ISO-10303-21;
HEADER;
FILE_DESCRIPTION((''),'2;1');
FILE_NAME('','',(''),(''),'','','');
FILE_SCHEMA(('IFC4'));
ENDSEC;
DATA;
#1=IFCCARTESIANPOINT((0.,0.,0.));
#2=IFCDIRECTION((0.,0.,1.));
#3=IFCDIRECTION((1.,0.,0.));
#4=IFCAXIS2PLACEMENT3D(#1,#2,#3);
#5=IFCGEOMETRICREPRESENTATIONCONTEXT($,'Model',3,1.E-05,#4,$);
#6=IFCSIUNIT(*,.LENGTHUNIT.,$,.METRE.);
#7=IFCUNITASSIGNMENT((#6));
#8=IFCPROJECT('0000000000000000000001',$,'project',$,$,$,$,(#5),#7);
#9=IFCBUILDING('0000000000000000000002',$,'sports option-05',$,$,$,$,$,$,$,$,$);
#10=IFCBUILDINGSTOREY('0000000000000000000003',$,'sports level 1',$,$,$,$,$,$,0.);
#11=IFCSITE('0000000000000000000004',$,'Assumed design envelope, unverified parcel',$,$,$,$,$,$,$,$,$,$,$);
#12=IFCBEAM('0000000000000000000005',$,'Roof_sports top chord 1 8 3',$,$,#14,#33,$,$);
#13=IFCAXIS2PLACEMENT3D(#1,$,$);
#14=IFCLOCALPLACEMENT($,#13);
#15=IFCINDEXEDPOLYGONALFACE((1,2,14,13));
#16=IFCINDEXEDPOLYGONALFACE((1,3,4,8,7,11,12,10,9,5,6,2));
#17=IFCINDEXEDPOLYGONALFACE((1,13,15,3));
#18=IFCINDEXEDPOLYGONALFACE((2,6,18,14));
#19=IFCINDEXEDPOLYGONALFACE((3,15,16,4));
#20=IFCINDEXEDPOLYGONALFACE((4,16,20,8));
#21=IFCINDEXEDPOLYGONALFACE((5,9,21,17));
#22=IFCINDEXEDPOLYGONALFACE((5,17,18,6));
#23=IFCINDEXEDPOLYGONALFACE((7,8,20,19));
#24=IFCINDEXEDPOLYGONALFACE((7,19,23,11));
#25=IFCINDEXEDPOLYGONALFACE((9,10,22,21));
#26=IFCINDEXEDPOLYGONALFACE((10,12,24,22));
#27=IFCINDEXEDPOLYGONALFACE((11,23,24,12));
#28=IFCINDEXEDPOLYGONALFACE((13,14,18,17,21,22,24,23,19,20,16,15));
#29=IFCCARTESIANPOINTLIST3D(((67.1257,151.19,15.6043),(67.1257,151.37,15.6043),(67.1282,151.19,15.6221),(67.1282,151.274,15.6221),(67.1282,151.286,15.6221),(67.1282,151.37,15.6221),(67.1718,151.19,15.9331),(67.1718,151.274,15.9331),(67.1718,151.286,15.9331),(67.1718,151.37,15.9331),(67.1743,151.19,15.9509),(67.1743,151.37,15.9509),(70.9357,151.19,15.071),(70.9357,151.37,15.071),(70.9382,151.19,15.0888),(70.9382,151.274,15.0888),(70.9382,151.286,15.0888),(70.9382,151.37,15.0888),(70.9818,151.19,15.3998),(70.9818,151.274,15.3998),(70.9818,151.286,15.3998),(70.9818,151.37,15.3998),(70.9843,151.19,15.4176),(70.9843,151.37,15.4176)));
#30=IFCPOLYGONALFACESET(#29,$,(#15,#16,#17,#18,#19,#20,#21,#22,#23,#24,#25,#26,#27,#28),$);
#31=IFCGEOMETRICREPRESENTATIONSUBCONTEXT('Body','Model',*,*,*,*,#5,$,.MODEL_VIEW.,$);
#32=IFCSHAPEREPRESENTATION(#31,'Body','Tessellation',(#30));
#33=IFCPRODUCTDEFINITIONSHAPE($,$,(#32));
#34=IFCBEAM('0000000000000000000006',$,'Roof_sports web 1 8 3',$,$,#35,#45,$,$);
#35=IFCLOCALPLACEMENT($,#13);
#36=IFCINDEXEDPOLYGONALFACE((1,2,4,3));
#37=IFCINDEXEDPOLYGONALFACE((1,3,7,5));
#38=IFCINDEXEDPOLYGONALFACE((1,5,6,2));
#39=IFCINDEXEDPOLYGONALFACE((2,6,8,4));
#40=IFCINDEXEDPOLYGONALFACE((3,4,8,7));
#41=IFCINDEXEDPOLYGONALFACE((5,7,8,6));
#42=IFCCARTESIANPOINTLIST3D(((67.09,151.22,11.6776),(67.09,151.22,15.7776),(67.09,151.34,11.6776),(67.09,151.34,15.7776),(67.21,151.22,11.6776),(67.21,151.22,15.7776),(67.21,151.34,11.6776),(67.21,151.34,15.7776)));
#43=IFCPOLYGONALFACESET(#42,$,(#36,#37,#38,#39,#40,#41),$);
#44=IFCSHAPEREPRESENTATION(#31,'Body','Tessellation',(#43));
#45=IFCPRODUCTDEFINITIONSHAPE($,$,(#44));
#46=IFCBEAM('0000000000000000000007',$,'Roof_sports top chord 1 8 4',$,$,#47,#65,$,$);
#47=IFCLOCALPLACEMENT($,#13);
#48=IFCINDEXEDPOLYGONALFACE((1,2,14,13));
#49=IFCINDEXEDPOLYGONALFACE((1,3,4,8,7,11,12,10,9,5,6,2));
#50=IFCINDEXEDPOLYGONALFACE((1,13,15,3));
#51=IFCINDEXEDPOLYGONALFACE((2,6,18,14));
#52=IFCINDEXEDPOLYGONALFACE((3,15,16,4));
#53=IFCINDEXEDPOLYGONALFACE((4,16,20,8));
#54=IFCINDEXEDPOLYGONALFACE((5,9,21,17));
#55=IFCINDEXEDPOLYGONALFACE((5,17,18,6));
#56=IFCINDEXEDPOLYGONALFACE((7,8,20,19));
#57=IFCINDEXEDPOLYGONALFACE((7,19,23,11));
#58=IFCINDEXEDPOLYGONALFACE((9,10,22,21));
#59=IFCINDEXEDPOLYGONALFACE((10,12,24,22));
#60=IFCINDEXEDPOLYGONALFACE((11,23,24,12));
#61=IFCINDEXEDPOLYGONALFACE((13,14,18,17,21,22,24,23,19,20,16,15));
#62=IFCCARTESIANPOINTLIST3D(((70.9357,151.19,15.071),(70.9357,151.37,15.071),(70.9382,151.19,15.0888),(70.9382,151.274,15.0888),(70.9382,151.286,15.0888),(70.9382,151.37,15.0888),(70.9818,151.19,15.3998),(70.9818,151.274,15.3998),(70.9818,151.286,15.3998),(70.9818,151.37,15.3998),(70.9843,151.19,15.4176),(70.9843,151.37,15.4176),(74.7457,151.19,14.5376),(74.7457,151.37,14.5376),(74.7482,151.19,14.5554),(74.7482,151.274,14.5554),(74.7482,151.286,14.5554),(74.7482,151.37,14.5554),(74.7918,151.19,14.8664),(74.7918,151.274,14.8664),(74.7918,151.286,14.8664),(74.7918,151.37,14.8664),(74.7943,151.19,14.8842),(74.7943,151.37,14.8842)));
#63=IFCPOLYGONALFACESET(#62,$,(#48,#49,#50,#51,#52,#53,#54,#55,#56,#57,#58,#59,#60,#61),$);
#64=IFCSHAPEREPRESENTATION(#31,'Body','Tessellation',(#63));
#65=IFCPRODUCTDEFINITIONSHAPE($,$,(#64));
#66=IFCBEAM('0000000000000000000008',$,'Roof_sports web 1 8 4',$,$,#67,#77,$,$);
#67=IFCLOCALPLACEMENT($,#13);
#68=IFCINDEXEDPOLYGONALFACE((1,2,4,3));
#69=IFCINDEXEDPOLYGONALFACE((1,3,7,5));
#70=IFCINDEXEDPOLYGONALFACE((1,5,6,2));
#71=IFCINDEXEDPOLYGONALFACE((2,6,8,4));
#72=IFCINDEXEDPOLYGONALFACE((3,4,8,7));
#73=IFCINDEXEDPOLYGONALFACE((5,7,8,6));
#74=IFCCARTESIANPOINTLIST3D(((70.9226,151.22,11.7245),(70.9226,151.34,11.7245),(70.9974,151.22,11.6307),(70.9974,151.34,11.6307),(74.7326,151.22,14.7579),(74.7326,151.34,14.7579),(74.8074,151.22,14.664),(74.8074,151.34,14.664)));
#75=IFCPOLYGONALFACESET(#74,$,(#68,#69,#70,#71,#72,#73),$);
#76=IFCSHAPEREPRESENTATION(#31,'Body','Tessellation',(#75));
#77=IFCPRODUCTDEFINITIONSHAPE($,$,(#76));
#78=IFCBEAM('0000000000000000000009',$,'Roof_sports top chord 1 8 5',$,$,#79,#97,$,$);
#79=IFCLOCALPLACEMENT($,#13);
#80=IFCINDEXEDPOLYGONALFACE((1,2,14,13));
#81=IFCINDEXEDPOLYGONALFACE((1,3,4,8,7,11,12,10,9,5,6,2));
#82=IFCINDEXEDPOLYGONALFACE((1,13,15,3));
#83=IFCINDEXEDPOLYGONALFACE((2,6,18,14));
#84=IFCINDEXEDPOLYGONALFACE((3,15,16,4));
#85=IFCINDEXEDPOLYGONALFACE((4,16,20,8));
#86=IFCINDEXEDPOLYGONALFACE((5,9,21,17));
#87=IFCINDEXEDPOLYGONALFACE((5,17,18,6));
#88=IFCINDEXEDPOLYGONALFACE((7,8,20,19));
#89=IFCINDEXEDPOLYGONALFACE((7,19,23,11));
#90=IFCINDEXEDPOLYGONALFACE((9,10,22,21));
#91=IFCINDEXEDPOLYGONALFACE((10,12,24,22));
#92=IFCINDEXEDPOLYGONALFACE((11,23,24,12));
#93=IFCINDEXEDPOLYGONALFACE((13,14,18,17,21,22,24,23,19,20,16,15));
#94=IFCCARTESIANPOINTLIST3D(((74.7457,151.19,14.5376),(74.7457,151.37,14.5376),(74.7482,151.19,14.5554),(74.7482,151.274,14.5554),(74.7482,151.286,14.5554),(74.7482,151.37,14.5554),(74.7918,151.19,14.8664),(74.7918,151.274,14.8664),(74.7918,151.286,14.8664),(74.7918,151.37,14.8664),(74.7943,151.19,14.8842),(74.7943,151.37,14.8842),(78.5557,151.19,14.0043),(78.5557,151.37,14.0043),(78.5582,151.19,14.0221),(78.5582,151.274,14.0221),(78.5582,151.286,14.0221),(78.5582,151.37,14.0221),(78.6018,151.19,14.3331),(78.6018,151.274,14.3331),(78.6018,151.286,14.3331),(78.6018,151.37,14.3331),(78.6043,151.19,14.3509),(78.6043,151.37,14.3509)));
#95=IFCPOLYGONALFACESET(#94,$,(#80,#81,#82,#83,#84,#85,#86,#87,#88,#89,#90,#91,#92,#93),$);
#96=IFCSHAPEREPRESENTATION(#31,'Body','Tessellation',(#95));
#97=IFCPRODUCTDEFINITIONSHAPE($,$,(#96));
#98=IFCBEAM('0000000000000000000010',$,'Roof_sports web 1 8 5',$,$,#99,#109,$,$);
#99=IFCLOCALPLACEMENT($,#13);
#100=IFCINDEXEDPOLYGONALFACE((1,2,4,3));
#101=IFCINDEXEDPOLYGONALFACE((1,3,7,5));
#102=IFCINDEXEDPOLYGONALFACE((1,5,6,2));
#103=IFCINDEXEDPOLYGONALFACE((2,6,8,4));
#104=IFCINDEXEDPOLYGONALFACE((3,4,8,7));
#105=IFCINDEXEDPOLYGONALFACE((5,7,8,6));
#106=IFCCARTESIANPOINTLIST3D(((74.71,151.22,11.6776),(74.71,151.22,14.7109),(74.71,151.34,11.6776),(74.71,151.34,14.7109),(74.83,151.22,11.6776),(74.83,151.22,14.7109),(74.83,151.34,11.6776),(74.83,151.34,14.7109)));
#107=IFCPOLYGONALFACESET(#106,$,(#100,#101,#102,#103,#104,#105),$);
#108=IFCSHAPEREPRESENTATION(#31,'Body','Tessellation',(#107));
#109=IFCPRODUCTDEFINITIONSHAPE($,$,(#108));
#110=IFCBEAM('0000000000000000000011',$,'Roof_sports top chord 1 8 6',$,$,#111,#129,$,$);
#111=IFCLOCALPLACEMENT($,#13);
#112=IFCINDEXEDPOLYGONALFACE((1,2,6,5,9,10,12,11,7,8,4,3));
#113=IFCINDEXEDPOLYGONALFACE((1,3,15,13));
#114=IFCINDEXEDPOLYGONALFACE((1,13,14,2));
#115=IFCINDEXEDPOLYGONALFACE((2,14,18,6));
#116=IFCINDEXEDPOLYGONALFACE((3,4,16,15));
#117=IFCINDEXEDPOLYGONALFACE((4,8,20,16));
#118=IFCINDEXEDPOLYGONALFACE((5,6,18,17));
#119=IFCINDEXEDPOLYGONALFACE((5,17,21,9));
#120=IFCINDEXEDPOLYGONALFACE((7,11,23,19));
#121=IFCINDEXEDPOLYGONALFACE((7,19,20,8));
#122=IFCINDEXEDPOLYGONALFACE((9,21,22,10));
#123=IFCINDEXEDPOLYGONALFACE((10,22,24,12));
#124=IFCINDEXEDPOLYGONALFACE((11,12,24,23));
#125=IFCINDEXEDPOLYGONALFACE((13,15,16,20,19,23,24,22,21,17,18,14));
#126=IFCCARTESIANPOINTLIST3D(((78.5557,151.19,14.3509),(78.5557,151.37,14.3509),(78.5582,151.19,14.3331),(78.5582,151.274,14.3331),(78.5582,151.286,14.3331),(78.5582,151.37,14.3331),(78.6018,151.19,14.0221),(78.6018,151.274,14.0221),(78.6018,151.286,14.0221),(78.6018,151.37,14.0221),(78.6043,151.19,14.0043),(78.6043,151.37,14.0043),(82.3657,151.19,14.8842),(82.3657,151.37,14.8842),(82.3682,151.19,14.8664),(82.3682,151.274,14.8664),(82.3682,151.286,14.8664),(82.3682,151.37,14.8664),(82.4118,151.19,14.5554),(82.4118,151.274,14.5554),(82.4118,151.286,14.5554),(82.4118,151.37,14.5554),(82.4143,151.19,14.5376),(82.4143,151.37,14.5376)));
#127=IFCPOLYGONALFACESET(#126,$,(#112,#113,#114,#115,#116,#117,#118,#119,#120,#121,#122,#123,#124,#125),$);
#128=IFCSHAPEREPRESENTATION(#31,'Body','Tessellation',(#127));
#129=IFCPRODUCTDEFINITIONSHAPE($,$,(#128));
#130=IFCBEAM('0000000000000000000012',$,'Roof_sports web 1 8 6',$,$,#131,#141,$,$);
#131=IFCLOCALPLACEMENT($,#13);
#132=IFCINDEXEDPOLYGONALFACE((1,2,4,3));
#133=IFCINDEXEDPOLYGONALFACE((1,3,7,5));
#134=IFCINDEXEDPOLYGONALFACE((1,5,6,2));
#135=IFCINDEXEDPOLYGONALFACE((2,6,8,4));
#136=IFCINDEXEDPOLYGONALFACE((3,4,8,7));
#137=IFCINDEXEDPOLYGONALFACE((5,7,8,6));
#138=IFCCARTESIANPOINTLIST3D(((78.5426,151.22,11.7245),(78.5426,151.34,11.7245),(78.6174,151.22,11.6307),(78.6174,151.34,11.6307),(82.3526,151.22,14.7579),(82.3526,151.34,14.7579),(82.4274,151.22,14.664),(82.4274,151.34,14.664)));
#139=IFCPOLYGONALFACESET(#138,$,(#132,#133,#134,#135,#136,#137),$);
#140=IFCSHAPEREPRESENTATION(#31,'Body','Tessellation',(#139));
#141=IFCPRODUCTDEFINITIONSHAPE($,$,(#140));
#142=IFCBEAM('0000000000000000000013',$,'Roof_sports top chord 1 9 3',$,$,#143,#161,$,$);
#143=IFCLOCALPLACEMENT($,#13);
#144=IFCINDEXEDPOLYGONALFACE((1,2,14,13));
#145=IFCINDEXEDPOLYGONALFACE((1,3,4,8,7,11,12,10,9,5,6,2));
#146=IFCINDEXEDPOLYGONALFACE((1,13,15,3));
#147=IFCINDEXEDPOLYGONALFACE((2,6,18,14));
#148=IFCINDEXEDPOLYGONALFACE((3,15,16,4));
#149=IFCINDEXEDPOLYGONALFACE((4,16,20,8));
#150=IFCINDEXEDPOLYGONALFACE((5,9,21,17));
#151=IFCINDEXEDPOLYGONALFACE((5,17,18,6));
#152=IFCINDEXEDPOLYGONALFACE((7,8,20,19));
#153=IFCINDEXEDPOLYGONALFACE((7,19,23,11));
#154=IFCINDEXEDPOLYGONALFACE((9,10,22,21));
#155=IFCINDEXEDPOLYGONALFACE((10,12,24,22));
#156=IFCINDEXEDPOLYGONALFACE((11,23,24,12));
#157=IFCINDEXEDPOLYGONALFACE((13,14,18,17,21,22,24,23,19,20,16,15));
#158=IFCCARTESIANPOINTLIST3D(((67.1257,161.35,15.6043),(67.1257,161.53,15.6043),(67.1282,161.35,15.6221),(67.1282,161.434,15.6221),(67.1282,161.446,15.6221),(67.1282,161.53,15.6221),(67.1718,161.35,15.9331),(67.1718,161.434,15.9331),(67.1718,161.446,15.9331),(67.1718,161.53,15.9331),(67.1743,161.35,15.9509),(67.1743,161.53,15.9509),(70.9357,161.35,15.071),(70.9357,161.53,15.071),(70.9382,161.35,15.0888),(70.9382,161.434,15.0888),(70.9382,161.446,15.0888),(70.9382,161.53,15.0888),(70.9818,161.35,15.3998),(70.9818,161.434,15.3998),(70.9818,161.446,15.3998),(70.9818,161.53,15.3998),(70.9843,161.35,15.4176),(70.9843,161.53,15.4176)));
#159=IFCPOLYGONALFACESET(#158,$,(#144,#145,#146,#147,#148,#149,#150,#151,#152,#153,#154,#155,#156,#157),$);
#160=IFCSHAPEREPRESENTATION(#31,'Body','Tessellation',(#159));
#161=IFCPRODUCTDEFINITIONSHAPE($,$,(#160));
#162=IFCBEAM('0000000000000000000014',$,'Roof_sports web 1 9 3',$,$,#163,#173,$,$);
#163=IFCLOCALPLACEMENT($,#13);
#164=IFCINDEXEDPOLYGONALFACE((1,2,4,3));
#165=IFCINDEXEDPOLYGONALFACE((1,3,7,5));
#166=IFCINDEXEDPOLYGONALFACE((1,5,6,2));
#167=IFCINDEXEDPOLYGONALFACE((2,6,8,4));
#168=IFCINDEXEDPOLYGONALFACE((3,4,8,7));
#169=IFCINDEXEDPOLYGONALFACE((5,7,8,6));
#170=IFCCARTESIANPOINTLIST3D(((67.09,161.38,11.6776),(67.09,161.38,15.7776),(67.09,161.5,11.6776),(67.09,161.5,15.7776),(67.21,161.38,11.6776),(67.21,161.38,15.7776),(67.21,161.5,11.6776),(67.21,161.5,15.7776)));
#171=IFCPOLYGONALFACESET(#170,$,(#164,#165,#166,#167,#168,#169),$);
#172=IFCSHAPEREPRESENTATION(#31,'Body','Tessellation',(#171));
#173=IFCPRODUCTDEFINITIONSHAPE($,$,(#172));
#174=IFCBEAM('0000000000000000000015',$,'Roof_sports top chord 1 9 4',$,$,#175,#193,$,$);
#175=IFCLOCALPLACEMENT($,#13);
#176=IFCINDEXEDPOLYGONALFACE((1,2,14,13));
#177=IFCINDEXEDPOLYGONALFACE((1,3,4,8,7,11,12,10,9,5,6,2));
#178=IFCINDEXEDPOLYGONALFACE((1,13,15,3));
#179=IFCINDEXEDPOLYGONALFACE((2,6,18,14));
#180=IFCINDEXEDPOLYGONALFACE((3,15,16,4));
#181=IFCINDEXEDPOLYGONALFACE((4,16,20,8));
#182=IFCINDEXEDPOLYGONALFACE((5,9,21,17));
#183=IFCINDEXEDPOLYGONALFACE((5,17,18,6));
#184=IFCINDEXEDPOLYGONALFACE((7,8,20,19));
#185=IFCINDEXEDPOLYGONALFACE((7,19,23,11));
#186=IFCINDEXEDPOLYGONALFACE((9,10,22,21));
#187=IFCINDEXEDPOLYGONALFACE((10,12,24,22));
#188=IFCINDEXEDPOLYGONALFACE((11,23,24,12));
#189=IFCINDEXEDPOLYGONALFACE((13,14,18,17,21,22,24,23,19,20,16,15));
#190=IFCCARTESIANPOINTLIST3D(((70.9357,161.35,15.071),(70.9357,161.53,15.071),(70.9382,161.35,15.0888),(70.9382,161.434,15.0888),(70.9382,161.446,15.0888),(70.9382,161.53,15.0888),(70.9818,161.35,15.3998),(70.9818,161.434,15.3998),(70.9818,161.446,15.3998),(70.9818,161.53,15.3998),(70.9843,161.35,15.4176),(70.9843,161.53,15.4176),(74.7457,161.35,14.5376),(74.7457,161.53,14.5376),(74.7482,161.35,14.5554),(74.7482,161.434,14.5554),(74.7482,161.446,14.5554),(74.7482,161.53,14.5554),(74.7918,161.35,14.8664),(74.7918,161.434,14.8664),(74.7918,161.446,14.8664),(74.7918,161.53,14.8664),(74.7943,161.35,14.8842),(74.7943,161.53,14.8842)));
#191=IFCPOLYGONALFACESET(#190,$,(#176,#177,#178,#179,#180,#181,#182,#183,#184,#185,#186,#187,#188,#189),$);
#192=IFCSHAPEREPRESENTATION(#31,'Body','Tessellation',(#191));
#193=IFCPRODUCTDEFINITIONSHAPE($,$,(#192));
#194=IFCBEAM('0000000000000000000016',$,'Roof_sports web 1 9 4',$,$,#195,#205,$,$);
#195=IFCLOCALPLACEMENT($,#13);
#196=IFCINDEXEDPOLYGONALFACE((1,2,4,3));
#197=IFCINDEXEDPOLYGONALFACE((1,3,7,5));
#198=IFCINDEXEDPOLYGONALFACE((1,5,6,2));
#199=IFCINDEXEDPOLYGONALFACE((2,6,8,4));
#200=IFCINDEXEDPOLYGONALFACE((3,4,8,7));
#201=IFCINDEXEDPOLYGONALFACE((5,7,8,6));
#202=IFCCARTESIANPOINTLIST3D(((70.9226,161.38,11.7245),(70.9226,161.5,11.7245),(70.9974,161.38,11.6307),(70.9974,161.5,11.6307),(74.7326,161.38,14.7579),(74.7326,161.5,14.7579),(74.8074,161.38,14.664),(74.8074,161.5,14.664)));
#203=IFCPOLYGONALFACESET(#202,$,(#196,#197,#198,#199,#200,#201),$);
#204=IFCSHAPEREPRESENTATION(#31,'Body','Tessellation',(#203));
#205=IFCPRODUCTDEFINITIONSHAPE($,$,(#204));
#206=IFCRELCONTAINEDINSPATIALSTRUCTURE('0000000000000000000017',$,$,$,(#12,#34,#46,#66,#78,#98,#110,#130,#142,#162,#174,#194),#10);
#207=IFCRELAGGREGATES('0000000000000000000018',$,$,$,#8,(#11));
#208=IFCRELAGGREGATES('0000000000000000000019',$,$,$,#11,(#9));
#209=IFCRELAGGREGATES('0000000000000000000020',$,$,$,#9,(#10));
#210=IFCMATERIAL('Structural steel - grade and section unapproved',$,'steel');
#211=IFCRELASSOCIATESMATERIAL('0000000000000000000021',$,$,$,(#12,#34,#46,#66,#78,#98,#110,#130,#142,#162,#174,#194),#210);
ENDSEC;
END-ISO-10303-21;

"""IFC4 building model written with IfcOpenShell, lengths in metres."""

from ifc_helpers import new_model, si_unit, frame, origin_with_axes, place, context, subcontext, project, spatial, rectangle, i_section, extrude, material, element, save


model = new_model("IFC4")

# Units and contexts
model_context = context("Model", 3, precision=1e-05, world=origin_with_axes())
body_context = subcontext(model_context, "Body", "Model", "MODEL_VIEW")
ifc_project = project(units=[si_unit("LENGTHUNIT", "METRE")], contexts=[model_context])

# Site, building, storey
site = spatial("IfcSite", under=ifc_project, Name="Assumed design envelope, unverified parcel")
building = spatial("IfcBuilding", under=site, Name="sports option-05")
storey = spatial("IfcBuildingStorey", under=building, Name="sports level 1", Elevation=0.0)

# Beams
ifc_material = material(Name="Structural steel - grade and section unapproved", Category="steel")
beam_1_placement = place(None, frame((67.15, 151.28, 15.7776), z_axis=(0.990344, 0.0, -0.138631), x_axis=(0.0, 1.0, 0.0)))
element("IfcBeam", 1, at=beam_1_placement, inside=storey, material=ifc_material, Name="Roof_sports top chord 1 8 3", context=body_context, shape_type="SweptSolid", body=[
    extrude(i_section(OverallWidth=0.18, OverallDepth=0.35, WebThickness=0.012, FlangeThickness=0.018, FilletRadius=0.0), origin_with_axes(), (0.0, 0.0, 1.0), 3.8471),
])
beam_2_placement = place(None, frame((67.15, 151.28, 11.6776), z_axis=(0.0, 0.0, 1.0), x_axis=(-1.0, 0.0, 0.0)))
element("IfcBeam", 2, at=beam_2_placement, inside=storey, material=ifc_material, Name="Roof_sports web 1 8 3", context=body_context, shape_type="SweptSolid", body=[
    extrude(rectangle(XDim=0.12, YDim=0.12), origin_with_axes(), (0.0, 0.0, 1.0), 4.1),
])
beam_3_placement = place(None, frame((70.96, 151.28, 15.2443), z_axis=(0.990344, 0.0, -0.138631), x_axis=(0.0, 1.0, 0.0)))
element("IfcBeam", 3, at=beam_3_placement, inside=storey, material=ifc_material, Name="Roof_sports top chord 1 8 4", context=body_context, shape_type="SweptSolid", body=[
    extrude(i_section(OverallWidth=0.18, OverallDepth=0.35, WebThickness=0.012, FlangeThickness=0.018, FilletRadius=0.0), origin_with_axes(), (0.0, 0.0, 1.0), 3.8471),
])
beam_4_placement = place(None, frame((70.96, 151.28, 11.6776), z_axis=(0.782336, 0.0, 0.622857), x_axis=(0.0, 1.0, 0.0)))
element("IfcBeam", 4, at=beam_4_placement, inside=storey, material=ifc_material, Name="Roof_sports web 1 8 4", context=body_context, shape_type="SweptSolid", body=[
    extrude(rectangle(XDim=0.12, YDim=0.12), origin_with_axes(), (0.0, 0.0, 1.0), 4.87),
])
beam_5_placement = place(None, frame((74.77, 151.28, 14.7109), z_axis=(0.990344, 0.0, -0.138631), x_axis=(0.0, 1.0, 0.0)))
element("IfcBeam", 5, at=beam_5_placement, inside=storey, material=ifc_material, Name="Roof_sports top chord 1 8 5", context=body_context, shape_type="SweptSolid", body=[
    extrude(i_section(OverallWidth=0.18, OverallDepth=0.35, WebThickness=0.012, FlangeThickness=0.018, FilletRadius=0.0), origin_with_axes(), (0.0, 0.0, 1.0), 3.8472),
])
beam_6_placement = place(None, frame((74.77, 151.28, 11.6776), z_axis=(0.0, 0.0, 1.0), x_axis=(-1.0, 0.0, 0.0)))
element("IfcBeam", 6, at=beam_6_placement, inside=storey, material=ifc_material, Name="Roof_sports web 1 8 5", context=body_context, shape_type="SweptSolid", body=[
    extrude(rectangle(XDim=0.12, YDim=0.12), origin_with_axes(), (0.0, 0.0, 1.0), 3.0333),
])
beam_7_placement = place(None, frame((78.58, 151.28, 14.1776), z_axis=(0.990344, 0.0, 0.138631), x_axis=(0.0, 1.0, 0.0)))
element("IfcBeam", 7, at=beam_7_placement, inside=storey, material=ifc_material, Name="Roof_sports top chord 1 8 6", context=body_context, shape_type="SweptSolid", body=[
    extrude(i_section(OverallWidth=0.18, OverallDepth=0.35, WebThickness=0.012, FlangeThickness=0.018, FilletRadius=0.0), origin_with_axes(), (0.0, 0.0, 1.0), 3.8471),
])
beam_8_placement = place(None, frame((78.58, 151.28, 11.6776), z_axis=(0.782336, 0.0, 0.622857), x_axis=(0.0, 1.0, 0.0)))
element("IfcBeam", 8, at=beam_8_placement, inside=storey, material=ifc_material, Name="Roof_sports web 1 8 6", context=body_context, shape_type="SweptSolid", body=[
    extrude(rectangle(XDim=0.12, YDim=0.12), origin_with_axes(), (0.0, 0.0, 1.0), 4.87),
])
beam_9_placement = place(None, frame((67.15, 161.44, 15.7776), z_axis=(0.990344, 0.0, -0.138631), x_axis=(0.0, 1.0, 0.0)))
element("IfcBeam", 9, at=beam_9_placement, inside=storey, material=ifc_material, Name="Roof_sports top chord 1 9 3", context=body_context, shape_type="SweptSolid", body=[
    extrude(i_section(OverallWidth=0.18, OverallDepth=0.35, WebThickness=0.012, FlangeThickness=0.018, FilletRadius=0.0), origin_with_axes(), (0.0, 0.0, 1.0), 3.8471),
])
beam_10_placement = place(None, frame((67.15, 161.44, 11.6776), z_axis=(0.0, 0.0, 1.0), x_axis=(-1.0, 0.0, 0.0)))
element("IfcBeam", 10, at=beam_10_placement, inside=storey, material=ifc_material, Name="Roof_sports web 1 9 3", context=body_context, shape_type="SweptSolid", body=[
    extrude(rectangle(XDim=0.12, YDim=0.12), origin_with_axes(), (0.0, 0.0, 1.0), 4.1),
])
beam_11_placement = place(None, frame((70.96, 161.44, 15.2443), z_axis=(0.990344, 0.0, -0.138631), x_axis=(0.0, 1.0, 0.0)))
element("IfcBeam", 11, at=beam_11_placement, inside=storey, material=ifc_material, Name="Roof_sports top chord 1 9 4", context=body_context, shape_type="SweptSolid", body=[
    extrude(i_section(OverallWidth=0.18, OverallDepth=0.35, WebThickness=0.012, FlangeThickness=0.018, FilletRadius=0.0), origin_with_axes(), (0.0, 0.0, 1.0), 3.8471),
])
beam_12_placement = place(None, frame((70.96, 161.44, 11.6776), z_axis=(0.782336, 0.0, 0.622857), x_axis=(0.0, 1.0, 0.0)))
element("IfcBeam", 12, at=beam_12_placement, inside=storey, material=ifc_material, Name="Roof_sports web 1 9 4", context=body_context, shape_type="SweptSolid", body=[
    extrude(rectangle(XDim=0.12, YDim=0.12), origin_with_axes(), (0.0, 0.0, 1.0), 4.87),
])

save(model, "model.ifc")
